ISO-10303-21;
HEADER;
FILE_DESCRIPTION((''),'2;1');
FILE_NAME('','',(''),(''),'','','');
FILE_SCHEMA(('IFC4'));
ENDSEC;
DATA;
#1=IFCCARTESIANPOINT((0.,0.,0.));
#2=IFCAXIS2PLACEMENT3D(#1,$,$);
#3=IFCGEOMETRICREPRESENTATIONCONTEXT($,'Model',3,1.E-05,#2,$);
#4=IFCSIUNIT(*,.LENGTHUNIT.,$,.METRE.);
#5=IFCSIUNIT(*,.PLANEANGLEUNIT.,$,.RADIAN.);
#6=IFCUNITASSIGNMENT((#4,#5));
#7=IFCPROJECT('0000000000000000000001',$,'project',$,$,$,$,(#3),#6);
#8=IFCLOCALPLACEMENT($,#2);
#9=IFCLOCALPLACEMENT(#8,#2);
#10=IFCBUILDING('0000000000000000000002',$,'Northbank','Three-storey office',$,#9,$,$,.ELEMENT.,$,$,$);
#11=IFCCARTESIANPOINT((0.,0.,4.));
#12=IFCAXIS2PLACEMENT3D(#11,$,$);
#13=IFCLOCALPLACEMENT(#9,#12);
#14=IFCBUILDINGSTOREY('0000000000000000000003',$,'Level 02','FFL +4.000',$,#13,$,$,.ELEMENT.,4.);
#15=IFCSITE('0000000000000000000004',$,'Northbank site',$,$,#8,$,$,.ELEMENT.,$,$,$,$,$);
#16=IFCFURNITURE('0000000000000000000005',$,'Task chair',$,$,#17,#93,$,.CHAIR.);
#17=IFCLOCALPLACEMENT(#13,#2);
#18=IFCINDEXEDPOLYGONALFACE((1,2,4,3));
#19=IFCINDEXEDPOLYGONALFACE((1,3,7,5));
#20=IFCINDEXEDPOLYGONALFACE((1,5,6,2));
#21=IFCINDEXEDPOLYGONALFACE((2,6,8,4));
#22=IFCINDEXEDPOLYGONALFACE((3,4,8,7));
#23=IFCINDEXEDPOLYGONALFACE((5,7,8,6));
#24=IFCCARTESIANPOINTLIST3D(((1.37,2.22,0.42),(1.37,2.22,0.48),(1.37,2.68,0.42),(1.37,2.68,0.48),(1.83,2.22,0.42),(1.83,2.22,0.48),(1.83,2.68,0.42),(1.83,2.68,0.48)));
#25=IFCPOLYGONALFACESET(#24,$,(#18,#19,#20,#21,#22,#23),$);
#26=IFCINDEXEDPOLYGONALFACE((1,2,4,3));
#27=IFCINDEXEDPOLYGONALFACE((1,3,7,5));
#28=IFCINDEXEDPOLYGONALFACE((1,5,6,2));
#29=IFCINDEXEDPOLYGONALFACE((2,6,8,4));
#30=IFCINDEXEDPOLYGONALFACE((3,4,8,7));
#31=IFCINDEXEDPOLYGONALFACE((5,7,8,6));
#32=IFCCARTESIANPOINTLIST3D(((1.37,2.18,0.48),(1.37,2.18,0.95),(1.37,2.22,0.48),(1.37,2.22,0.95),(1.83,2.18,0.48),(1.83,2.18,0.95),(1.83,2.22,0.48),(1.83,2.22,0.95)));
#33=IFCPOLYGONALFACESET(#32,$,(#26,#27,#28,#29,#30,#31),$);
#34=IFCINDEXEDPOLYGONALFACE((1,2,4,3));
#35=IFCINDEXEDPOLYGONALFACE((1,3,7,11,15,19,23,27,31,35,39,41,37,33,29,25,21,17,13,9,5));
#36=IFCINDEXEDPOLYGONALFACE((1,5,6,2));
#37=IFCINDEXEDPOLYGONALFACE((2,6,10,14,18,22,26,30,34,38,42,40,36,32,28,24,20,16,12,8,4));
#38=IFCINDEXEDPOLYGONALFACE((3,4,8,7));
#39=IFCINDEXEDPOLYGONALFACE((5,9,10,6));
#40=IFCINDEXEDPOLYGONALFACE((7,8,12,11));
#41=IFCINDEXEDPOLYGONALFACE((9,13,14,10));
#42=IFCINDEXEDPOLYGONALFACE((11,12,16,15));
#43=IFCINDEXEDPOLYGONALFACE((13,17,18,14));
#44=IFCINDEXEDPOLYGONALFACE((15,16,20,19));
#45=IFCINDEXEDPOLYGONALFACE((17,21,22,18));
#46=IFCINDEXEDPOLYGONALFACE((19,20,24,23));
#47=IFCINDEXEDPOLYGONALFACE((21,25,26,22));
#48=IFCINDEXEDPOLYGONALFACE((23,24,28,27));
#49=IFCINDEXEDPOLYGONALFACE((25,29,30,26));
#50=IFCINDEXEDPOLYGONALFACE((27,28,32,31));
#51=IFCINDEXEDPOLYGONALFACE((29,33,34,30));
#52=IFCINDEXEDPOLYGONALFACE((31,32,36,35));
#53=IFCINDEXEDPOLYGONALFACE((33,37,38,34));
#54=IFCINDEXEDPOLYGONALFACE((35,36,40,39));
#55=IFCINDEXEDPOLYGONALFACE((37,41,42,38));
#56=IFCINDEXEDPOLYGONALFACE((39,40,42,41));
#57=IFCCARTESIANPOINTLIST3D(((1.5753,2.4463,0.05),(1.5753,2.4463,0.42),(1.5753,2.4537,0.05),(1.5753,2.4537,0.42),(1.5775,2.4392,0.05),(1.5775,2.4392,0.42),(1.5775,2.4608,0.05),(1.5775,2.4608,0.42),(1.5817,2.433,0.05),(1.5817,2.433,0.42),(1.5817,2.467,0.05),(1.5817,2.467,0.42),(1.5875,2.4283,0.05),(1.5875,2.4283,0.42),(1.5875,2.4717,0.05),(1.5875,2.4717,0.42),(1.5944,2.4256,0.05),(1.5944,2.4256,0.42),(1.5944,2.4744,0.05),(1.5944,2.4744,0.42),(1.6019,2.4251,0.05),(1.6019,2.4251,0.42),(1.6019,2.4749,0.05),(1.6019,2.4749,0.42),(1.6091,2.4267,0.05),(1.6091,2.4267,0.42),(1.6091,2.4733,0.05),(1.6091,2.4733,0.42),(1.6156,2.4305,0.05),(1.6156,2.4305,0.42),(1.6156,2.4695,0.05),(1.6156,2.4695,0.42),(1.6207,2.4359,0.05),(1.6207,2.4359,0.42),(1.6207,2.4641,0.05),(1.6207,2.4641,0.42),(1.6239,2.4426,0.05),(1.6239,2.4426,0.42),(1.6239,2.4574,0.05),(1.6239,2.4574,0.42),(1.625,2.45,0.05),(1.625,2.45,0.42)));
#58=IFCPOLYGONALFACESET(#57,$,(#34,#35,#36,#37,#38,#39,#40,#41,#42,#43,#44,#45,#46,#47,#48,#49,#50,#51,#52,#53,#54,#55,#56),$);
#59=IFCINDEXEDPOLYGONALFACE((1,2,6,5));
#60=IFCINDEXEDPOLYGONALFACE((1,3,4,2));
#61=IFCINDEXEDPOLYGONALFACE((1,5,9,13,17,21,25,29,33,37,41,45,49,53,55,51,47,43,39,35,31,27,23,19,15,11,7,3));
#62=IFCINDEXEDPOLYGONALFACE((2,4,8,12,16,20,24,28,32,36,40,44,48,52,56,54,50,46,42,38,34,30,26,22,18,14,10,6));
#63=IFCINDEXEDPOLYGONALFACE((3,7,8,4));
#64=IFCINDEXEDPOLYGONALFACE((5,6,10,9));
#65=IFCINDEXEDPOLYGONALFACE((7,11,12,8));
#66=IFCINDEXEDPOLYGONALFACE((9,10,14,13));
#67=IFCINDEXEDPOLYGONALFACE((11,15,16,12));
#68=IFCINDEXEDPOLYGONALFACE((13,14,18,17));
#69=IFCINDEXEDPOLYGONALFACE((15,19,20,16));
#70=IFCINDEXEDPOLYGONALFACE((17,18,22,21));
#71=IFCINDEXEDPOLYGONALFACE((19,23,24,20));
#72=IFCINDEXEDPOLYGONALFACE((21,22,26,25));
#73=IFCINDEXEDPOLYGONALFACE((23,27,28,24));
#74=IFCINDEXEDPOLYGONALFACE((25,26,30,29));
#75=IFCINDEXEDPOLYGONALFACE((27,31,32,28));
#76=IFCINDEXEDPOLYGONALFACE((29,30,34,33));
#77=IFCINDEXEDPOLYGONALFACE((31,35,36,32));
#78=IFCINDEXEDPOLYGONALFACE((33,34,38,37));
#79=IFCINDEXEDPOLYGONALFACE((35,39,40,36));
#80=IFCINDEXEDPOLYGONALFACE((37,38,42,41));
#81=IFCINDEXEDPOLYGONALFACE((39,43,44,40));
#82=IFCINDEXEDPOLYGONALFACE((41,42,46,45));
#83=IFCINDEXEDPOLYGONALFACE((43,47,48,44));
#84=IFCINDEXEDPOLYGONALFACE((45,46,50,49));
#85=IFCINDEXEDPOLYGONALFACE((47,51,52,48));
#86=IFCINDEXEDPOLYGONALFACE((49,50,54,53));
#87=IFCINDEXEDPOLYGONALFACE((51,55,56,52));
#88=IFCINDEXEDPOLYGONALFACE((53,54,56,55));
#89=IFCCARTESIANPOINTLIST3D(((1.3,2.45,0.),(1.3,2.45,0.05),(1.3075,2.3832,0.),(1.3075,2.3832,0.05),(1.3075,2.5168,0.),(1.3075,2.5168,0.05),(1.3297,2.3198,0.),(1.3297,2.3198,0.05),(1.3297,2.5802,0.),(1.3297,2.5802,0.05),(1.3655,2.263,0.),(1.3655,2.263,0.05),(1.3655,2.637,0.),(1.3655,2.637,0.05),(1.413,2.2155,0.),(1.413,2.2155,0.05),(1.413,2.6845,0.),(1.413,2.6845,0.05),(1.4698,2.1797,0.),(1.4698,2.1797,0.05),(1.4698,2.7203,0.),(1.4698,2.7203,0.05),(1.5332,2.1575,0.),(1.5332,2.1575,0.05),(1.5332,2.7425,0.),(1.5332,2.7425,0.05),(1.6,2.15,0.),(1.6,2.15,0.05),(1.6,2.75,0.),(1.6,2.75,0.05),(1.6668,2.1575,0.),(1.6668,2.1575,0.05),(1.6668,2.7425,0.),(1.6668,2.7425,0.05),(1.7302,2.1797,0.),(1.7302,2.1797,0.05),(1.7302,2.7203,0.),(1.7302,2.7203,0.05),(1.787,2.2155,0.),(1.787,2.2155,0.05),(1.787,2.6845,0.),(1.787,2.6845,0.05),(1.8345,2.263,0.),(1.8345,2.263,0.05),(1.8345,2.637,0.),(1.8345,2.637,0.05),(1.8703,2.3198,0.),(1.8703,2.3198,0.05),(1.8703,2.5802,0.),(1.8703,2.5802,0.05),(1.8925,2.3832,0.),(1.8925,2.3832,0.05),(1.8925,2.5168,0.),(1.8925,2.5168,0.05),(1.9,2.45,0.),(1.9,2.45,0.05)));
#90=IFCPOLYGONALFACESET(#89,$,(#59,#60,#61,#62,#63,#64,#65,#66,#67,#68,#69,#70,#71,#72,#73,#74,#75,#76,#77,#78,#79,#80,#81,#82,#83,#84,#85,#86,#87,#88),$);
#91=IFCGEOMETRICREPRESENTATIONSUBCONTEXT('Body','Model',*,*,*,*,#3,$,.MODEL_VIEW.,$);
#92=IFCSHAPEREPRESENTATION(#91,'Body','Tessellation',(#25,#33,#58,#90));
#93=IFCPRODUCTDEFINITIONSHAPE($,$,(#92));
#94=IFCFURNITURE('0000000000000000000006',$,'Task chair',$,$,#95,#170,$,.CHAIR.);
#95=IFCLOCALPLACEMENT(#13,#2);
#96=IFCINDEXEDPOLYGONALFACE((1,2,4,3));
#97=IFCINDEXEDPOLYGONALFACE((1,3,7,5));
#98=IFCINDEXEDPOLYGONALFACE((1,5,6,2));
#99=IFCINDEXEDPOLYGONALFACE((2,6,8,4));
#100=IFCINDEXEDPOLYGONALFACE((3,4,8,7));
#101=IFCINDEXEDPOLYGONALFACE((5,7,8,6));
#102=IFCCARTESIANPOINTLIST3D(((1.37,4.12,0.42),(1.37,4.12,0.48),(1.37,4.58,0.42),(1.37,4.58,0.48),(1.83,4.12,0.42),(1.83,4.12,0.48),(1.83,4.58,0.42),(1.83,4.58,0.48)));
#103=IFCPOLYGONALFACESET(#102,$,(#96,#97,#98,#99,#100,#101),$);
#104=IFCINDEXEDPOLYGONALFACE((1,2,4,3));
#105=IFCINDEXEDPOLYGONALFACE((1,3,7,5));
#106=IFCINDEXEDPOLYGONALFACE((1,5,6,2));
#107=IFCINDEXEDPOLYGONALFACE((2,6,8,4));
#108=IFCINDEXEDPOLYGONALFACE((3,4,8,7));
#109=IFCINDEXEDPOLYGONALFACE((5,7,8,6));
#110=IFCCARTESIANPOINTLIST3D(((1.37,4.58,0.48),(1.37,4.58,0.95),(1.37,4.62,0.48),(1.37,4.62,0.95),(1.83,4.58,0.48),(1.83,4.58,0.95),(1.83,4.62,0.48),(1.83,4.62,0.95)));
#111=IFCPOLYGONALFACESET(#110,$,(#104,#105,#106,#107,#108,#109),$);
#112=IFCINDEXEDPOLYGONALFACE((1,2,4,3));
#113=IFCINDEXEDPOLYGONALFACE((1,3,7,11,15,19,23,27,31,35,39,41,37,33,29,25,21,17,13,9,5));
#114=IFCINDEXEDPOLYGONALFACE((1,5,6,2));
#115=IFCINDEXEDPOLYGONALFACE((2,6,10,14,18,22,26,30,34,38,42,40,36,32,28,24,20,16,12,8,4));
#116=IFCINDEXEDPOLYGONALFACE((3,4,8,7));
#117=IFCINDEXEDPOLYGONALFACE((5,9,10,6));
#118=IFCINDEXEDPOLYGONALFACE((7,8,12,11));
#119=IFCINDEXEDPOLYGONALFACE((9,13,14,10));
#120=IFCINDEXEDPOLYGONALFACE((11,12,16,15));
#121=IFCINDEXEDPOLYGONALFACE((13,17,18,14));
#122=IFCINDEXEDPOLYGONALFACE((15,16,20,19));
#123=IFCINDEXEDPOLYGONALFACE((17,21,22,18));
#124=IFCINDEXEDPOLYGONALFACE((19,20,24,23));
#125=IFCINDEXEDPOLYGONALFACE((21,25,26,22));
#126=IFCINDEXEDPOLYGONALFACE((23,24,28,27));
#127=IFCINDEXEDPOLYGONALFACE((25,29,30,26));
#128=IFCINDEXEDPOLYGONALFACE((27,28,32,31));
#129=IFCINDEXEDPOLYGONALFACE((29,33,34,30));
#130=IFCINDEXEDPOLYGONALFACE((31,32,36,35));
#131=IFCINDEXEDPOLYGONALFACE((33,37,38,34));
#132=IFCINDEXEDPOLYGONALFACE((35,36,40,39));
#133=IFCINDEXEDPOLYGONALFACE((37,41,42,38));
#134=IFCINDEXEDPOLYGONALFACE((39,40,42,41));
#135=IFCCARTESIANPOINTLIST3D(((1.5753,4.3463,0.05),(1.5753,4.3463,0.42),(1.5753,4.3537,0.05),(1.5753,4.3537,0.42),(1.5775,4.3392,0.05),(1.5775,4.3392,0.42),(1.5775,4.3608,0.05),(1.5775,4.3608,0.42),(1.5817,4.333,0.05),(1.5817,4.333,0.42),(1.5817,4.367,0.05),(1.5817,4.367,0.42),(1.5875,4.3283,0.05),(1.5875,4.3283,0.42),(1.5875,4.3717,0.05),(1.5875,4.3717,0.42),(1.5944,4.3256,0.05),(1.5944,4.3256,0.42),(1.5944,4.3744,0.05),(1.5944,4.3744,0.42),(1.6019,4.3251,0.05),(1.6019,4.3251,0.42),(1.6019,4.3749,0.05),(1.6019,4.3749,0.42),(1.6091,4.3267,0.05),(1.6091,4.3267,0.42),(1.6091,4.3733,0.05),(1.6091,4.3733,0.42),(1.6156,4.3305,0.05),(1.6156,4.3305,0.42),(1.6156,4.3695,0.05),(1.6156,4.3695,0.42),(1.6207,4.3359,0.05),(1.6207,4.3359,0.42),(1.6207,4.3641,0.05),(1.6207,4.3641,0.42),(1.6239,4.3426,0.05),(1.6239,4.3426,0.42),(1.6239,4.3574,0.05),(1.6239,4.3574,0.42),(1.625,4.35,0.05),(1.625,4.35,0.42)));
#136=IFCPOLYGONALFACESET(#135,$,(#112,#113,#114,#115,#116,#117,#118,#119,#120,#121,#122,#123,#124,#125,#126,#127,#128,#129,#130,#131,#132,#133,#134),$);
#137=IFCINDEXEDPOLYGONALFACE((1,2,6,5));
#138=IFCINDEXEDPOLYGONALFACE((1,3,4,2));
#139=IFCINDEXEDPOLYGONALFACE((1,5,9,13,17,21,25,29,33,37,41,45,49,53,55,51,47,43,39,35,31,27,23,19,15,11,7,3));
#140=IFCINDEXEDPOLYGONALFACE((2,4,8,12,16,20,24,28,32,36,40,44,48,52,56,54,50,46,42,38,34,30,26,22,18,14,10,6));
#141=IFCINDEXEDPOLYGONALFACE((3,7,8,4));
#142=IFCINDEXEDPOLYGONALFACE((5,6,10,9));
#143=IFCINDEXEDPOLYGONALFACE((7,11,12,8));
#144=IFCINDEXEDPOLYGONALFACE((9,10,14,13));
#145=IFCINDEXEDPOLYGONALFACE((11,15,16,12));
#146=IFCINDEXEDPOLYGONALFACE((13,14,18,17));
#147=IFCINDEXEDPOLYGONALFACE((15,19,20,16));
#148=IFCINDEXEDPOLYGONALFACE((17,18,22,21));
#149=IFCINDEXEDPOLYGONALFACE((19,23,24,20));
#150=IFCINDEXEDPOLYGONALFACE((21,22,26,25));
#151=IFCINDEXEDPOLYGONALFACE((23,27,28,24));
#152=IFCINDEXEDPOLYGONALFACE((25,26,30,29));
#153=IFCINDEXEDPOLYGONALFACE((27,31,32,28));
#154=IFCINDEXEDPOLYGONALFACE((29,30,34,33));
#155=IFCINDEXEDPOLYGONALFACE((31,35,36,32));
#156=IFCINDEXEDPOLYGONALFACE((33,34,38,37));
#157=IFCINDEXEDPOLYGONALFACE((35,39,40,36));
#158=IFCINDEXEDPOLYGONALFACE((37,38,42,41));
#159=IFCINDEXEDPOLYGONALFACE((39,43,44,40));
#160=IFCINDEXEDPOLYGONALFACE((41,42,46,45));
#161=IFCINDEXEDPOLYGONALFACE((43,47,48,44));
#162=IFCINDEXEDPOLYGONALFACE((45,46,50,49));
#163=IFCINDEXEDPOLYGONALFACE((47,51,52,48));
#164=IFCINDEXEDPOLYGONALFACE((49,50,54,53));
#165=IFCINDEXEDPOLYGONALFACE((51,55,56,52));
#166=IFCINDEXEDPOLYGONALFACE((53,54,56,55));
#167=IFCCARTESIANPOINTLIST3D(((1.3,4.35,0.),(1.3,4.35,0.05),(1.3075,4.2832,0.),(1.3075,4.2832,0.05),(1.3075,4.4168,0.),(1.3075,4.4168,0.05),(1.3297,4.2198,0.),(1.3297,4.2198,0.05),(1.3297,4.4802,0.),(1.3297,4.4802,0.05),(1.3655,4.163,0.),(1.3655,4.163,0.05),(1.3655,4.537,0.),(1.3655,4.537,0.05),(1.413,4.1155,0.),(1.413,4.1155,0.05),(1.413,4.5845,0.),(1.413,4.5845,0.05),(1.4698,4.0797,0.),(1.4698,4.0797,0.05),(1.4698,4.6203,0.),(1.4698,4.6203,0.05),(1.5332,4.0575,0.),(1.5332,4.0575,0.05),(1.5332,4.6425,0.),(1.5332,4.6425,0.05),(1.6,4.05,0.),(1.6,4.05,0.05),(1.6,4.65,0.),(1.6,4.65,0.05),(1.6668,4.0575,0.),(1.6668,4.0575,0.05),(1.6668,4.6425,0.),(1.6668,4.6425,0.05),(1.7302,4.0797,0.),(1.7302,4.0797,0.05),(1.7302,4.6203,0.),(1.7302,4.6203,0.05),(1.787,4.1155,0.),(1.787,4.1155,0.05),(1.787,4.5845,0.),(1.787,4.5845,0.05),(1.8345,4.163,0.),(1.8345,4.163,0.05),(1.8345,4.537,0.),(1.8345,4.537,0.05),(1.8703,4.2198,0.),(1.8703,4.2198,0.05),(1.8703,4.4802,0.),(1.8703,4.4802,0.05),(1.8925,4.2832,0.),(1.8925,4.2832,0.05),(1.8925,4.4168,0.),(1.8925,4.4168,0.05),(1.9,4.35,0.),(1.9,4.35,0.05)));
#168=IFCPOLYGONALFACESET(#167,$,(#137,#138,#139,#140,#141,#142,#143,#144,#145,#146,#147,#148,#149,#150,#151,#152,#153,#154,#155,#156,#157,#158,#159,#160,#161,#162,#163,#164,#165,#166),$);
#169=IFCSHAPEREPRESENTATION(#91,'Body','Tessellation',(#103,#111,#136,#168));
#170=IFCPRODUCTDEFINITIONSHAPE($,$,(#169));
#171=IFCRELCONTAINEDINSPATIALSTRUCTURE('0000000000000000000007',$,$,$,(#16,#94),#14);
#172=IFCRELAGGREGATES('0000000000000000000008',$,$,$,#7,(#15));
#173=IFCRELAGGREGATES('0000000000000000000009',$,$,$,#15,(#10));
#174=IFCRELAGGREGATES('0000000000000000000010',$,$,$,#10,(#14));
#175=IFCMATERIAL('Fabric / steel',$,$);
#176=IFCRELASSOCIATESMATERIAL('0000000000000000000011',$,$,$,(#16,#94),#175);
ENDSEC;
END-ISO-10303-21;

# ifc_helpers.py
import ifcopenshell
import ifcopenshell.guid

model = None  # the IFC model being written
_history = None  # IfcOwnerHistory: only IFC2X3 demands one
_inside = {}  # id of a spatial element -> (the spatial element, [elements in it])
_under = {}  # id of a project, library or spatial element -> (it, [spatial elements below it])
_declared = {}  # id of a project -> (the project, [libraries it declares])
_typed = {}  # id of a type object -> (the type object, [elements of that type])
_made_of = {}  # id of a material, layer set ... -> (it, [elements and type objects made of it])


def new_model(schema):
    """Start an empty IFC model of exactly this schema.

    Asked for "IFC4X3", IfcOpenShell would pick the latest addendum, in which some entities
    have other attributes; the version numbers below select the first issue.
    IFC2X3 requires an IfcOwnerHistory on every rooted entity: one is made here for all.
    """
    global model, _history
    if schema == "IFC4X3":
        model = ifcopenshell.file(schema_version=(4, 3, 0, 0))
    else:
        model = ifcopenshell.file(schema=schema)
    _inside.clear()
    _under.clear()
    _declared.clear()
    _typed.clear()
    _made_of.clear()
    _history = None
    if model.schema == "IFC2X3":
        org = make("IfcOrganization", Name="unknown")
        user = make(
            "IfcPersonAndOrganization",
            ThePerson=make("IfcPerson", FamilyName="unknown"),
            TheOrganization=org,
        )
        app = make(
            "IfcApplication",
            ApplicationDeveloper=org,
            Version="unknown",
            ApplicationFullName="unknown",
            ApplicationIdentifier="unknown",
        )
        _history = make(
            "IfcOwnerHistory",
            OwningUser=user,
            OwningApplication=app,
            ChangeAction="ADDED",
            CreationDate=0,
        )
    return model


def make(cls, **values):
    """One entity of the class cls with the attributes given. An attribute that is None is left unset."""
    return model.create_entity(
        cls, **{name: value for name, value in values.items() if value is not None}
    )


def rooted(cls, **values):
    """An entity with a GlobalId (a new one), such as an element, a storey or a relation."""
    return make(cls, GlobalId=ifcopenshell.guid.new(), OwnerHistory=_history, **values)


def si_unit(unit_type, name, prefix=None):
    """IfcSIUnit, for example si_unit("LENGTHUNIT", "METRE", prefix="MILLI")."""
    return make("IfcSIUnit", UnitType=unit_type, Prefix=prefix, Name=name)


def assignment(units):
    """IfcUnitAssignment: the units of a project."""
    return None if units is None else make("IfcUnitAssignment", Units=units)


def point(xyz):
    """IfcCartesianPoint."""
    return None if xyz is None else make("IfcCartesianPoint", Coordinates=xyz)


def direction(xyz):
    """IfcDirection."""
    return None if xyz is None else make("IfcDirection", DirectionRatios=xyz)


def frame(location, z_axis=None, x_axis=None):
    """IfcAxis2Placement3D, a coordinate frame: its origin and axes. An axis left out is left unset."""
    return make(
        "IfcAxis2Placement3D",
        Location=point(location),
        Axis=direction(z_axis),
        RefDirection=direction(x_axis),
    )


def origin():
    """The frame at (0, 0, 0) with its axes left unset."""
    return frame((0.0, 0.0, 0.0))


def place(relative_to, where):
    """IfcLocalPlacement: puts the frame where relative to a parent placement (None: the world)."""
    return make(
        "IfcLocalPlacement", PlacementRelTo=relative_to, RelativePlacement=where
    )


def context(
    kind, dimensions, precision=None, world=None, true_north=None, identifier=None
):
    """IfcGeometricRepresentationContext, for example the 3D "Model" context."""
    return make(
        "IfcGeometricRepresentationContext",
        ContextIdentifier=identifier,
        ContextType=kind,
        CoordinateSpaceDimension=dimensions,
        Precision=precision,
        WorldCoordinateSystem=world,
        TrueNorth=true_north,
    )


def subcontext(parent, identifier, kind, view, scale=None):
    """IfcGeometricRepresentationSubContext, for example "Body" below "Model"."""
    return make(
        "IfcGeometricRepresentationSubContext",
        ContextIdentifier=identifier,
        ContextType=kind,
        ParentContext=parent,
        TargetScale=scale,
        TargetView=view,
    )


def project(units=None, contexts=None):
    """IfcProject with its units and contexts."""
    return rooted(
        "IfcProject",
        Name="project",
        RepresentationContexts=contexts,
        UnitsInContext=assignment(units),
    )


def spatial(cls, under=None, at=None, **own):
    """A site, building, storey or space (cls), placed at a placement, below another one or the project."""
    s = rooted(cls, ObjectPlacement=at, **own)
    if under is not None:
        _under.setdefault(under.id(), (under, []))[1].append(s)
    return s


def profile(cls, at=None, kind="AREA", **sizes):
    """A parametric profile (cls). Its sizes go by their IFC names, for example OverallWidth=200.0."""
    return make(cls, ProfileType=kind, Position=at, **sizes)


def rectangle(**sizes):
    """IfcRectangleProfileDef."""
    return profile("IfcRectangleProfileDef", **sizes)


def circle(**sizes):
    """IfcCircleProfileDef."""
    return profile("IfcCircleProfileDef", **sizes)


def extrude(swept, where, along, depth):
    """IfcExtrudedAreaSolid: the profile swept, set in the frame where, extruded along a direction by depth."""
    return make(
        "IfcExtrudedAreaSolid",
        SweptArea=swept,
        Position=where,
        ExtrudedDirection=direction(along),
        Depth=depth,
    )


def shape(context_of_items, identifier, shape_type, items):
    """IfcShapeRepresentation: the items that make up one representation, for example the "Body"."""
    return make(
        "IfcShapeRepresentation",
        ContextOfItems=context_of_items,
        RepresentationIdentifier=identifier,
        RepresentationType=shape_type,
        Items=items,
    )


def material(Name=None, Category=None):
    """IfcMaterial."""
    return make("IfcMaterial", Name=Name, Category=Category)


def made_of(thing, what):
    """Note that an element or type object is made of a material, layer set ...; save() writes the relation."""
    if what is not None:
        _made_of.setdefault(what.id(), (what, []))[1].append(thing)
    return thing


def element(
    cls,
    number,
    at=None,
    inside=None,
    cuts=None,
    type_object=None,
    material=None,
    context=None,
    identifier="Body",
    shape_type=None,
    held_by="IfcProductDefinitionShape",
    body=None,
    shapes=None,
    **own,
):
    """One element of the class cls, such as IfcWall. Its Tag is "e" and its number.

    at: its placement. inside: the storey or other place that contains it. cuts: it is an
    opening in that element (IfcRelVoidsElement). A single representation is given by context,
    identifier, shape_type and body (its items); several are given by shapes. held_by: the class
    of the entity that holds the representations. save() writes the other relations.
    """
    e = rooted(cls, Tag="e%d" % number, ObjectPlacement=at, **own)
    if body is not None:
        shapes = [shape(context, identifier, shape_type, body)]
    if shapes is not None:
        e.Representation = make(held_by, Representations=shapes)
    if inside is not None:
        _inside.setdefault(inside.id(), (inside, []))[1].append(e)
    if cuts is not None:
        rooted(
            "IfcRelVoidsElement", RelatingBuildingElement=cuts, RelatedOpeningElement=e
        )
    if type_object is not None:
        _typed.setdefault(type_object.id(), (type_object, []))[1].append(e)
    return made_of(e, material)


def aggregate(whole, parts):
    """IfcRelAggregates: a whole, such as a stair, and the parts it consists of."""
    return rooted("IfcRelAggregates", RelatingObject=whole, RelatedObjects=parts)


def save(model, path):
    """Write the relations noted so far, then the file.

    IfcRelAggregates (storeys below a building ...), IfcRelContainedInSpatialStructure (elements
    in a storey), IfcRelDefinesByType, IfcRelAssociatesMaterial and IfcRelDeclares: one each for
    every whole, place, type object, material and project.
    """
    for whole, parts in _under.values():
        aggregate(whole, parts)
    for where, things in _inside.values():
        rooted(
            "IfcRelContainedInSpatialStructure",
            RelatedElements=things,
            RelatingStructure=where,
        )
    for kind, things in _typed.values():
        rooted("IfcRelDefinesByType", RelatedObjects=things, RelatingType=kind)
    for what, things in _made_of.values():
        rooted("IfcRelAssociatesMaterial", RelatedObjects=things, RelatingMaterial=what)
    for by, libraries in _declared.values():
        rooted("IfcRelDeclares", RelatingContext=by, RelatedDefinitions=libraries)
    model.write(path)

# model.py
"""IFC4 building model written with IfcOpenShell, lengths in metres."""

from ifc_helpers import new_model, si_unit, frame, origin, place, context, subcontext, project, spatial, rectangle, circle, extrude, material, element, save


model = new_model("IFC4")

# Units and contexts
model_context = context("Model", 3, precision=1e-05, world=origin())
body_context = subcontext(model_context, "Body", "Model", "MODEL_VIEW")
ifc_project = project(units=[si_unit("LENGTHUNIT", "METRE"), si_unit("PLANEANGLEUNIT", "RADIAN")], contexts=[model_context])

# Site, building, storey
site_placement = place(None, origin())
site = spatial("IfcSite", under=ifc_project, at=site_placement, Name="Northbank site", CompositionType="ELEMENT")
building_placement = place(site_placement, origin())
building = spatial("IfcBuilding", under=site, at=building_placement, Name="Northbank", Description="Three-storey office", CompositionType="ELEMENT")
storey_placement = place(building_placement, frame((0.0, 0.0, 4.0)))
storey = spatial("IfcBuildingStorey", under=building, at=storey_placement, Name="Level 02", Description="FFL +4.000", CompositionType="ELEMENT", Elevation=4.0)

# Furniture
ifc_material_1 = material(Name="Fabric / steel")
furniture_1_placement = place(storey_placement, frame((0.0, 0.0, -4.0)))
element("IfcFurniture", 1, at=furniture_1_placement, inside=storey, material=ifc_material_1, Name="Task chair", PredefinedType="CHAIR", context=body_context, shape_type="SweptSolid", body=[
    extrude(rectangle(XDim=0.46, YDim=0.46), frame((1.6, 2.45, 4.42)), (0.0, 0.0, 1.0), 0.06),
    extrude(rectangle(XDim=0.46, YDim=0.04), frame((1.6, 2.2, 4.48)), (0.0, 0.0, 1.0), 0.47),
    extrude(circle(Radius=0.025), frame((1.6, 2.45, 4.05), z_axis=(0.0, 0.0, 1.0), x_axis=(1.0, 0.0, 0.0)), (0.0, 0.0, 1.0), 0.37),
    extrude(circle(Radius=0.3), frame((1.6, 2.45, 4.0), z_axis=(0.0, 0.0, 1.0), x_axis=(1.0, 0.0, 0.0)), (0.0, 0.0, 1.0), 0.05),
])
furniture_2_placement = place(storey_placement, frame((0.0, 0.0, -4.0)))
element("IfcFurniture", 2, at=furniture_2_placement, inside=storey, material=ifc_material_1, Name="Task chair", PredefinedType="CHAIR", context=body_context, shape_type="SweptSolid", body=[
    extrude(rectangle(XDim=0.46, YDim=0.46), frame((1.6, 4.35, 4.42)), (0.0, 0.0, 1.0), 0.06),
    extrude(rectangle(XDim=0.46, YDim=0.04), frame((1.6, 4.6, 4.48)), (0.0, 0.0, 1.0), 0.47),
    extrude(circle(Radius=0.025), frame((1.6, 4.35, 4.05), z_axis=(0.0, 0.0, 1.0), x_axis=(1.0, 0.0, 0.0)), (0.0, 0.0, 1.0), 0.37),
    extrude(circle(Radius=0.3), frame((1.6, 4.35, 4.0), z_axis=(0.0, 0.0, 1.0), x_axis=(1.0, 0.0, 0.0)), (0.0, 0.0, 1.0), 0.05),
])

save(model, "model.ifc")
